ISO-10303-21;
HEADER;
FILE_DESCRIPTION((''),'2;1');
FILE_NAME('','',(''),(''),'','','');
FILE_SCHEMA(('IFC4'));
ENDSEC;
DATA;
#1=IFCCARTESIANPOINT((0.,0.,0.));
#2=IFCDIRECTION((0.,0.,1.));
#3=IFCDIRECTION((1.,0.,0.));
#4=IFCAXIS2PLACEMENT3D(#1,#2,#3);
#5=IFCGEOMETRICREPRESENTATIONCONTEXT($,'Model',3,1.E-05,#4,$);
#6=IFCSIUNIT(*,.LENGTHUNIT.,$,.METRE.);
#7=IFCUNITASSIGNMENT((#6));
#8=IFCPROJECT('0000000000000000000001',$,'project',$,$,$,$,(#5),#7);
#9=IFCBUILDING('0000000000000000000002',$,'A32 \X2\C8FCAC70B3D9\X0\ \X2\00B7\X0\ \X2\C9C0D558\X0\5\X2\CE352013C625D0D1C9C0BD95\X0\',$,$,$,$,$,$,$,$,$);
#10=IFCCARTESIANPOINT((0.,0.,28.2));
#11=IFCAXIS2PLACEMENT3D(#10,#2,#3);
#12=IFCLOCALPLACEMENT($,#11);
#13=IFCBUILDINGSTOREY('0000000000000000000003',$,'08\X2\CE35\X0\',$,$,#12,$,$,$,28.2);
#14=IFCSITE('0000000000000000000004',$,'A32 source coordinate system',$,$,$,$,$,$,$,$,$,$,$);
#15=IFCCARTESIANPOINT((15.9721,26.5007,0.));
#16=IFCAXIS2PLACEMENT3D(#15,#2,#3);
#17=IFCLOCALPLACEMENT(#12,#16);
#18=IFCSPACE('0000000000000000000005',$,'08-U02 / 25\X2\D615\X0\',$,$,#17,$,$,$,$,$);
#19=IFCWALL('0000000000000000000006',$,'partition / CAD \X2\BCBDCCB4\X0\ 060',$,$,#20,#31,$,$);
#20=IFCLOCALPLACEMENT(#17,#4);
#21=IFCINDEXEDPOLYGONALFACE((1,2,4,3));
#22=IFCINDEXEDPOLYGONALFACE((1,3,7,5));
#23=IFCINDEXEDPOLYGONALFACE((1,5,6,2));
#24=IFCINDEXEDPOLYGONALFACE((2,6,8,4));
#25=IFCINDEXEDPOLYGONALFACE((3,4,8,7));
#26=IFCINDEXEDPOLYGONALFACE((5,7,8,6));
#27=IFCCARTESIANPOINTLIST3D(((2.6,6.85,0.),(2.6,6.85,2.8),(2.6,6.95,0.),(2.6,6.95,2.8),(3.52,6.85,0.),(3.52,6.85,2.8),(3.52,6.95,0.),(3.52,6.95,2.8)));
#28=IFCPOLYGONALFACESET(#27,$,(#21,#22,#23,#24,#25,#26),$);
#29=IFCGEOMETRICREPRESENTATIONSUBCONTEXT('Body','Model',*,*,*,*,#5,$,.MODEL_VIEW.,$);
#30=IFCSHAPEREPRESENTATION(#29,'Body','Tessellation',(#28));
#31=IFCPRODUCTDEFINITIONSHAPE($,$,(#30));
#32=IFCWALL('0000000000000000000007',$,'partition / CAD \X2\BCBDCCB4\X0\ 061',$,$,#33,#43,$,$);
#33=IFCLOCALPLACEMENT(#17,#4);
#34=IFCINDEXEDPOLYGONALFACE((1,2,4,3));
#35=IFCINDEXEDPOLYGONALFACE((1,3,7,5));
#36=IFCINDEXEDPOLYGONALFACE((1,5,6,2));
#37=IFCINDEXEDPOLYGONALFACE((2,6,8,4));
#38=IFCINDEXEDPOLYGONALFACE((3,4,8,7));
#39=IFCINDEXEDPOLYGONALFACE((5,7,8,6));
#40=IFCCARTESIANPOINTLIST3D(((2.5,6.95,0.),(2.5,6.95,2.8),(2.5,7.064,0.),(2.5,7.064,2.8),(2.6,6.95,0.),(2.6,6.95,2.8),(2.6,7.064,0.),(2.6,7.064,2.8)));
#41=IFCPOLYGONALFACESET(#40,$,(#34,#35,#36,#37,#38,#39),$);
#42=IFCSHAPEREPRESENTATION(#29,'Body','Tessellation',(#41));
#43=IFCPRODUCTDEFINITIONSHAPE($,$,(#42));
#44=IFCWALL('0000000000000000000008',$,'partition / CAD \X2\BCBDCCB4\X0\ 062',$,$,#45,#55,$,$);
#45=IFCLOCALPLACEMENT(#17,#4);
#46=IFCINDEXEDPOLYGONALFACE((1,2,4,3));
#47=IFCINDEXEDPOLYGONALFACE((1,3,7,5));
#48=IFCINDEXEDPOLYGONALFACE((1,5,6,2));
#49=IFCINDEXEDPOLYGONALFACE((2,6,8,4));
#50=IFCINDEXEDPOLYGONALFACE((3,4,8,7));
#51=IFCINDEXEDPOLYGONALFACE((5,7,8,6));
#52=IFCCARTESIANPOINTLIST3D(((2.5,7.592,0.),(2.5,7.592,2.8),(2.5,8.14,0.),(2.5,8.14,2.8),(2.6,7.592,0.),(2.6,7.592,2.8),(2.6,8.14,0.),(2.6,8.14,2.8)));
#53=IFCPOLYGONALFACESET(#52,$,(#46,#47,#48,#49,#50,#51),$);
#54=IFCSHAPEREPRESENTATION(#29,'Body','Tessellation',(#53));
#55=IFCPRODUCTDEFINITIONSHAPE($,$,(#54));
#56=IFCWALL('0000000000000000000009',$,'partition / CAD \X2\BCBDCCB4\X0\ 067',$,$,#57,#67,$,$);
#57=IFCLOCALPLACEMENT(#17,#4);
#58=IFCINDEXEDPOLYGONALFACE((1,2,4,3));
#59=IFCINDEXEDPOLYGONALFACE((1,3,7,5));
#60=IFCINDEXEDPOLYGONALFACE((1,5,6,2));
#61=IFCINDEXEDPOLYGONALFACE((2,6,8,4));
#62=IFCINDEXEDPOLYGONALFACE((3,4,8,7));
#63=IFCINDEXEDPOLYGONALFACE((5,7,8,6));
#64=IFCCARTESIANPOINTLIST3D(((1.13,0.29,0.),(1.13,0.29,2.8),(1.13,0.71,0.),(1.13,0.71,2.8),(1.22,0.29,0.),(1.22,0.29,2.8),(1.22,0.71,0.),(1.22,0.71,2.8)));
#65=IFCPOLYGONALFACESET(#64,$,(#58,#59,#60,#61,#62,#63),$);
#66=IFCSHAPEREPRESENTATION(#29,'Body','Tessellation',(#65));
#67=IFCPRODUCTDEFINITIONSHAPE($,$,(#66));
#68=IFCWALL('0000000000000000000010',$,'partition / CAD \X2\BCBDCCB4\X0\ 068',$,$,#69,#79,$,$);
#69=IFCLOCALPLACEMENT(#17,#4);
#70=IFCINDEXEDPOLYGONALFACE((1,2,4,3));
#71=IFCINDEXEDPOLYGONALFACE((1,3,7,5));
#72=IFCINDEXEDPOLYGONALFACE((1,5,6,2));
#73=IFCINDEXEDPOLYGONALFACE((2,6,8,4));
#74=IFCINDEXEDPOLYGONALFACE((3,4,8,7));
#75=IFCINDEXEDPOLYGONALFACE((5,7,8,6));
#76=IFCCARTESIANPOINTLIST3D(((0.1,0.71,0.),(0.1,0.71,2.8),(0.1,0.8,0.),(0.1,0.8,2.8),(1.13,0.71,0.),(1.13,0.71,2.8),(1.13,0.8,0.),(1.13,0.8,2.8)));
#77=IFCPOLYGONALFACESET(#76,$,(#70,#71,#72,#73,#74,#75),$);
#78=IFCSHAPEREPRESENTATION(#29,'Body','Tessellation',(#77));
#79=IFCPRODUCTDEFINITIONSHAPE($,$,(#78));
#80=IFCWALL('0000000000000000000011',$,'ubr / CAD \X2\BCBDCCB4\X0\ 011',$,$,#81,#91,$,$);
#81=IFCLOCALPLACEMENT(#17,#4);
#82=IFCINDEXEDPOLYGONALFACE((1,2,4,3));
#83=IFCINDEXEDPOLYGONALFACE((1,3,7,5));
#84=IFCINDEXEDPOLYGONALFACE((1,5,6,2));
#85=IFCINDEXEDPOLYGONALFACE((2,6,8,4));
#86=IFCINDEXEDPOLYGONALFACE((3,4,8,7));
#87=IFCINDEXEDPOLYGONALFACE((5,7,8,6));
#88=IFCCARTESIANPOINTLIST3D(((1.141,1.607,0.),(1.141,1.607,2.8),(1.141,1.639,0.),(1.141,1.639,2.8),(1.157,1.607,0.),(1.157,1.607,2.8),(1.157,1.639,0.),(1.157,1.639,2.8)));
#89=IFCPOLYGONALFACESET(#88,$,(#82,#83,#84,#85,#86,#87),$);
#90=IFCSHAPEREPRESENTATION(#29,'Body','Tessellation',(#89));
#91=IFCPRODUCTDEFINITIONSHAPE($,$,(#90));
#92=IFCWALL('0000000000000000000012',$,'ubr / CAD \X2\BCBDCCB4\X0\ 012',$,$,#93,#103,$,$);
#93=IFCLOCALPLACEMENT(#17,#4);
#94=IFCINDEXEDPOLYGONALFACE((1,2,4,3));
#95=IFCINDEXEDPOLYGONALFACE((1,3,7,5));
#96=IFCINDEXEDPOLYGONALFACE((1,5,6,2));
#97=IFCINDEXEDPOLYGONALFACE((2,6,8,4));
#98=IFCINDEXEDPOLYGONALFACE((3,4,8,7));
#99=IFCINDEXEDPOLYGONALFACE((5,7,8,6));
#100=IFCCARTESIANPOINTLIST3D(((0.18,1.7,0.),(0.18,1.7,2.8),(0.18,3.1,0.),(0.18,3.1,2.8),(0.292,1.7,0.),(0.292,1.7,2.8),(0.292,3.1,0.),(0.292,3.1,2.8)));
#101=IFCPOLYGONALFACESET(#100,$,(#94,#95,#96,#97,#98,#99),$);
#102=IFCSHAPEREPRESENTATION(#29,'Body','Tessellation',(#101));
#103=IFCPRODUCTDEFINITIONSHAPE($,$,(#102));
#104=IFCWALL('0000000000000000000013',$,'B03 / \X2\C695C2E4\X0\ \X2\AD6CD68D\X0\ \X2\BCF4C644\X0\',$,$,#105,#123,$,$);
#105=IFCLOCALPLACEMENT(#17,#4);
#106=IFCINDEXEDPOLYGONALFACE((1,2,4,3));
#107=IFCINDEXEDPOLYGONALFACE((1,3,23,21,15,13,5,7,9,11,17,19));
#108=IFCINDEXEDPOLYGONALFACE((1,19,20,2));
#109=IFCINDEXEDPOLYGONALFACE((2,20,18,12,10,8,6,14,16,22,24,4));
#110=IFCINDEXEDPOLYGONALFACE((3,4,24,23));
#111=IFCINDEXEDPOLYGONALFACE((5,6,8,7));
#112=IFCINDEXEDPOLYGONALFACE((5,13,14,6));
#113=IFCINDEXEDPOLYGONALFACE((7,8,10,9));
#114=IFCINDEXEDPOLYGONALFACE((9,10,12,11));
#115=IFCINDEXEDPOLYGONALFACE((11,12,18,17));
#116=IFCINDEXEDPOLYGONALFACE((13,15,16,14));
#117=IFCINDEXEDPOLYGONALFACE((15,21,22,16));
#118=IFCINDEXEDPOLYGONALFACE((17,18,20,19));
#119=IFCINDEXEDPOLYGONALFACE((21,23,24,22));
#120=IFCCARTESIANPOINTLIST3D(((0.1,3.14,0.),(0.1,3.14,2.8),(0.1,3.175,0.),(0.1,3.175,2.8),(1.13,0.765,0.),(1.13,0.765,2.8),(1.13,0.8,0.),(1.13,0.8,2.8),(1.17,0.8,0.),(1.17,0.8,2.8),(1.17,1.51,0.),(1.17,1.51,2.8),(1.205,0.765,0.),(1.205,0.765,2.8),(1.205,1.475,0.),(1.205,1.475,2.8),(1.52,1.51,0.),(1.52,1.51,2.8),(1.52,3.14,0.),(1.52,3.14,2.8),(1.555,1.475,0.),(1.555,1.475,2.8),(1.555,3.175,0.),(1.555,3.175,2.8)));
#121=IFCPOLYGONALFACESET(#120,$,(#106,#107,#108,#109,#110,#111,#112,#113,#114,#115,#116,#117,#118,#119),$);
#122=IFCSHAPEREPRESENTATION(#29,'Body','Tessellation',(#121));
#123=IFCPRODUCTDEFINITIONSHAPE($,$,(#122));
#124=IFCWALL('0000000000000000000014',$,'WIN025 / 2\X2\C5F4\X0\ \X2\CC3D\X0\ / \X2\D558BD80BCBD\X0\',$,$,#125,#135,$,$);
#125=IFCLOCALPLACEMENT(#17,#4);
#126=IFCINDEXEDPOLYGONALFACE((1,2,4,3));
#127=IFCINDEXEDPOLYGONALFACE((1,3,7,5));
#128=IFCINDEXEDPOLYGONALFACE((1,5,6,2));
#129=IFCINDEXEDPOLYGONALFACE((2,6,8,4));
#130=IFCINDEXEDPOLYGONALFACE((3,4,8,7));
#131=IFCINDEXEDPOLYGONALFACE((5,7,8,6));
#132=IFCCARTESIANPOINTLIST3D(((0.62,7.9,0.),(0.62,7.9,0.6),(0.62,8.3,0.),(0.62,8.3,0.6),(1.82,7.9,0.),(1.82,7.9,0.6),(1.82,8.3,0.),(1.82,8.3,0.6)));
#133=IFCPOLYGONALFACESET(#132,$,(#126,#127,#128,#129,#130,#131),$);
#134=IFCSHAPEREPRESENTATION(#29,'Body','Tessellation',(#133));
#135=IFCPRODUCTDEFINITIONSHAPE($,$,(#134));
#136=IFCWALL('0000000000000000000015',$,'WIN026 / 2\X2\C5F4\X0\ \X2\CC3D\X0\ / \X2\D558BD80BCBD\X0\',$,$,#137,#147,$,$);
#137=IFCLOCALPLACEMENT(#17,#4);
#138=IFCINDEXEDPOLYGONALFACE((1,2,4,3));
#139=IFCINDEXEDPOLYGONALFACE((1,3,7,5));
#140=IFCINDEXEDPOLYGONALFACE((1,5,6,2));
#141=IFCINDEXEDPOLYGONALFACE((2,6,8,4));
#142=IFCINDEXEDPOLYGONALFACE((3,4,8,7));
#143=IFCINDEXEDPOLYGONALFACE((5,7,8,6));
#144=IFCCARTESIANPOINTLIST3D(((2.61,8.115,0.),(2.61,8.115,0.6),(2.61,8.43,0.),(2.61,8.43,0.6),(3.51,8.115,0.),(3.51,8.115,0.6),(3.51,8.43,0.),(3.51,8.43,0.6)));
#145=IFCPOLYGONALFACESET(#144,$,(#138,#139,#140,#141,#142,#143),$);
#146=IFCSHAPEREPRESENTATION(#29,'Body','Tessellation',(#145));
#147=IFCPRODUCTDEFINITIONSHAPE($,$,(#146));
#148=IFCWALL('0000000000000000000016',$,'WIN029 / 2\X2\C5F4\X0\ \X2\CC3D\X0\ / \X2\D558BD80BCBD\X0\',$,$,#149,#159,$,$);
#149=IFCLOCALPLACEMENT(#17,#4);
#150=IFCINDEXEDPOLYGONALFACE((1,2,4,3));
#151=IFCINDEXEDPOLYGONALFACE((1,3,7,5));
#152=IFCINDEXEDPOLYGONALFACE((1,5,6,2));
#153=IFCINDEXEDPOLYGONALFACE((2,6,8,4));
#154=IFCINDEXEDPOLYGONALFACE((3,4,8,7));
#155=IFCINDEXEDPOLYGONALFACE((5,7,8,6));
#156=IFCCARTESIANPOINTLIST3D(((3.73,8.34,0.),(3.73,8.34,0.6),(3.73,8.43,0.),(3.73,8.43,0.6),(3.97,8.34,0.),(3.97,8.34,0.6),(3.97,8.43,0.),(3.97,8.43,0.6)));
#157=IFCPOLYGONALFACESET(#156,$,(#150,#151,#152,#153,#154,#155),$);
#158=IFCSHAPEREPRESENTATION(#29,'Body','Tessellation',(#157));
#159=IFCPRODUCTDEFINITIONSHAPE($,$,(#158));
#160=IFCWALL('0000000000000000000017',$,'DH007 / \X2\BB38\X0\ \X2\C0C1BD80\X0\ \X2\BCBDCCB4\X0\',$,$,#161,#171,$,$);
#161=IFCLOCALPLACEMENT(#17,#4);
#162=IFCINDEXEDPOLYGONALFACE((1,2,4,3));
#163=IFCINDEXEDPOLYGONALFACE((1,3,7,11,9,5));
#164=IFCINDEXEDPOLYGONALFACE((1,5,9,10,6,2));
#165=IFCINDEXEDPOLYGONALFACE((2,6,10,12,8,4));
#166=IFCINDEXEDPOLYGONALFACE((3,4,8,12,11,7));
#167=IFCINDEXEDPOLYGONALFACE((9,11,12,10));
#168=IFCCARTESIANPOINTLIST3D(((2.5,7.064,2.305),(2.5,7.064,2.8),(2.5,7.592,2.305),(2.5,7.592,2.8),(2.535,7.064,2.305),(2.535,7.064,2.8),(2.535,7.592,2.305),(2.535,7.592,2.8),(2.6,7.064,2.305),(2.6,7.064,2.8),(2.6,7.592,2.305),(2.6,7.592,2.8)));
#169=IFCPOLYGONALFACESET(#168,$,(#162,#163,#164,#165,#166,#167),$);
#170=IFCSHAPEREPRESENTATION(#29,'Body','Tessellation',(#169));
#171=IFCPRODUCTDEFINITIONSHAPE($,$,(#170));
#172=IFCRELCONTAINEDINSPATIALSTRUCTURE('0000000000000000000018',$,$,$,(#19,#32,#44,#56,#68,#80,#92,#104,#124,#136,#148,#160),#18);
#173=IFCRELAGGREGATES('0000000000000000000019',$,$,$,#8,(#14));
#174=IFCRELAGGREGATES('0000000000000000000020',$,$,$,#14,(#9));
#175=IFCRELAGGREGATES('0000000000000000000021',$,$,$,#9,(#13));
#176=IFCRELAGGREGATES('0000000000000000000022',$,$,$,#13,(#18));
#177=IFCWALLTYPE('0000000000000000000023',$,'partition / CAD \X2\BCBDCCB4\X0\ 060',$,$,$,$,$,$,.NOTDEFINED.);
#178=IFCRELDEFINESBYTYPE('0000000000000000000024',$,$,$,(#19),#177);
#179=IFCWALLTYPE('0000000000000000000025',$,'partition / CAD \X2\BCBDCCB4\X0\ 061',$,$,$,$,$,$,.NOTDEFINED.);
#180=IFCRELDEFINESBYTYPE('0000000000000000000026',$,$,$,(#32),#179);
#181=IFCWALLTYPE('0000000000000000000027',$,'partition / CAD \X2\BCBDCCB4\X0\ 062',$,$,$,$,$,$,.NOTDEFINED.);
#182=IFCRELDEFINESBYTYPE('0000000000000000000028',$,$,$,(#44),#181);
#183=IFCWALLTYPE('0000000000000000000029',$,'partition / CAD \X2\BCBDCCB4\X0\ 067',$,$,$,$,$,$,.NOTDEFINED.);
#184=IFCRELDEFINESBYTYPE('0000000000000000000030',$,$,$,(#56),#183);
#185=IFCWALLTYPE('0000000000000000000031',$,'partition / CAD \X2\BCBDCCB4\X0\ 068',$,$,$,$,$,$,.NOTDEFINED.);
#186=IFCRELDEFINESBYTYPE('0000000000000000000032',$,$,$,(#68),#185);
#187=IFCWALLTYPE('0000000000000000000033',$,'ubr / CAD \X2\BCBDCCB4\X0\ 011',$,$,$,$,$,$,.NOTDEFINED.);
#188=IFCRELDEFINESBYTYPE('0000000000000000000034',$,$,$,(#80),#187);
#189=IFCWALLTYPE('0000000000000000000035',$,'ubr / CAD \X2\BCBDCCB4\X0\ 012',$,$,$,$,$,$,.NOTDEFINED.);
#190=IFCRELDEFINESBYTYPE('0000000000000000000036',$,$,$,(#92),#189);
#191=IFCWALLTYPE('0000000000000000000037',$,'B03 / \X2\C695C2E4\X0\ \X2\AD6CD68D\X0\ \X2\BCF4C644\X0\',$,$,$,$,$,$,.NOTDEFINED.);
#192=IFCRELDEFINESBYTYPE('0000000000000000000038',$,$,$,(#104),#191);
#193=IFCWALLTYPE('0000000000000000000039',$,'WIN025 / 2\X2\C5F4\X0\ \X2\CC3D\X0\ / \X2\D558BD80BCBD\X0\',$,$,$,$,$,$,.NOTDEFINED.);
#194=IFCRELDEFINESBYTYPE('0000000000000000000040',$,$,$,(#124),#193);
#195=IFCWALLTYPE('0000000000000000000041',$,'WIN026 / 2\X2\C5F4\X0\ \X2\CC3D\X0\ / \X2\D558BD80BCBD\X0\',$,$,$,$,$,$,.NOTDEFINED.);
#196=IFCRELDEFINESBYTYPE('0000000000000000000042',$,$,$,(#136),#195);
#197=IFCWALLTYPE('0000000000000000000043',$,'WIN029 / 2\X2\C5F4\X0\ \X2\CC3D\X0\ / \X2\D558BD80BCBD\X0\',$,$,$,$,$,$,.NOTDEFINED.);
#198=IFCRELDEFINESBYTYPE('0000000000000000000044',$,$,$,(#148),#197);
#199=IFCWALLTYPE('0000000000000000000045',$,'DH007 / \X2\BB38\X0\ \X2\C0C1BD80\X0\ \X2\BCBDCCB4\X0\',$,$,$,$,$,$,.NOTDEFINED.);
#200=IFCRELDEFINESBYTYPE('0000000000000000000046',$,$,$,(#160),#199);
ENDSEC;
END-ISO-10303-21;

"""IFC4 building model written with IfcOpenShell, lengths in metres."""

from ifc_helpers import new_model, si_unit, frame, origin, origin_with_axes, place, context, subcontext, project, spatial, polyline, outline, extrude, source, transform, mapped, type_object, type_shapes, element, save


model = new_model("IFC4")

# Units and contexts
model_context = context("Model", 3, precision=1e-05, world=origin_with_axes())
body_context = subcontext(model_context, "Body", "Model", "MODEL_VIEW")
ifc_project = project(units=[si_unit("LENGTHUNIT", "METRE")], contexts=[model_context])

# Site, building, storey, space
site = spatial("IfcSite", under=ifc_project, Name="A32 source coordinate system")
building = spatial("IfcBuilding", under=site, Name="A32 주거동 · 지하5층–옥탑지붕")
storey_placement = place(None, frame((0.0, 0.0, 28.2), z_axis=(0.0, 0.0, 1.0), x_axis=(1.0, 0.0, 0.0)))
storey = spatial("IfcBuildingStorey", under=building, at=storey_placement, Name="08층", Elevation=28.2)
space_1_placement = place(storey_placement, frame((15.9721, 26.5007, 0.0), z_axis=(0.0, 0.0, 1.0), x_axis=(1.0, 0.0, 0.0)))
space_1 = spatial("IfcSpace", under=storey, at=space_1_placement, Name="08-U02 / 25형")

# Walls
wall_type_1 = type_object("IfcWallType", Name="partition / CAD 벽체 060", PredefinedType="NOTDEFINED")
shared_shape_1 = source(origin(), body_context, "Body", "SweptSolid", [
    extrude(outline(polyline([(3.52, 6.85), (2.6, 6.85), (2.6, 6.95), (3.52, 6.95), (3.52, 6.85)])), origin(), (0.0, 0.0, 1.0), 2.8),
])
type_shapes(wall_type_1, [shared_shape_1])
wall_1_placement = place(space_1_placement, origin_with_axes())
element("IfcWall", 1, at=wall_1_placement, inside=space_1, type_object=wall_type_1, Name="partition / CAD 벽체 060", context=body_context, shape_type="MappedRepresentation", body=[
    mapped(shared_shape_1, transform((0.0, 0.0, 0.0), scale=1.0)),
])
wall_type_2 = type_object("IfcWallType", Name="partition / CAD 벽체 061", PredefinedType="NOTDEFINED")
shared_shape_2 = source(origin(), body_context, "Body", "SweptSolid", [
    extrude(outline(polyline([(2.6, 7.064), (2.6, 6.95), (2.5, 6.95), (2.5, 7.064), (2.6, 7.064)])), origin(), (0.0, 0.0, 1.0), 2.8),
])
type_shapes(wall_type_2, [shared_shape_2])
wall_2_placement = place(space_1_placement, origin_with_axes())
element("IfcWall", 2, at=wall_2_placement, inside=space_1, type_object=wall_type_2, Name="partition / CAD 벽체 061", context=body_context, shape_type="MappedRepresentation", body=[
    mapped(shared_shape_2, transform((0.0, 0.0, 0.0), scale=1.0)),
])
wall_type_3 = type_object("IfcWallType", Name="partition / CAD 벽체 062", PredefinedType="NOTDEFINED")
shared_shape_3 = source(origin(), body_context, "Body", "SweptSolid", [
    extrude(outline(polyline([(2.5, 7.592), (2.5, 8.14), (2.6, 8.14), (2.6, 7.592), (2.5, 7.592)])), origin(), (0.0, 0.0, 1.0), 2.8),
])
type_shapes(wall_type_3, [shared_shape_3])
wall_3_placement = place(space_1_placement, origin_with_axes())
element("IfcWall", 3, at=wall_3_placement, inside=space_1, type_object=wall_type_3, Name="partition / CAD 벽체 062", context=body_context, shape_type="MappedRepresentation", body=[
    mapped(shared_shape_3, transform((0.0, 0.0, 0.0), scale=1.0)),
])
wall_type_4 = type_object("IfcWallType", Name="partition / CAD 벽체 067", PredefinedType="NOTDEFINED")
shared_shape_4 = source(origin(), body_context, "Body", "SweptSolid", [
    extrude(outline(polyline([(1.22, 0.71), (1.22, 0.29), (1.13, 0.29), (1.13, 0.71), (1.22, 0.71)])), origin(), (0.0, 0.0, 1.0), 2.8),
])
type_shapes(wall_type_4, [shared_shape_4])
wall_4_placement = place(space_1_placement, origin_with_axes())
element("IfcWall", 4, at=wall_4_placement, inside=space_1, type_object=wall_type_4, Name="partition / CAD 벽체 067", context=body_context, shape_type="MappedRepresentation", body=[
    mapped(shared_shape_4, transform((0.0, 0.0, 0.0), scale=1.0)),
])
wall_type_5 = type_object("IfcWallType", Name="partition / CAD 벽체 068", PredefinedType="NOTDEFINED")
shared_shape_5 = source(origin(), body_context, "Body", "SweptSolid", [
    extrude(outline(polyline([(1.13, 0.8), (1.13, 0.71), (0.1, 0.71), (0.1, 0.8), (1.13, 0.8)])), origin(), (0.0, 0.0, 1.0), 2.8),
])
type_shapes(wall_type_5, [shared_shape_5])
wall_5_placement = place(space_1_placement, origin_with_axes())
element("IfcWall", 5, at=wall_5_placement, inside=space_1, type_object=wall_type_5, Name="partition / CAD 벽체 068", context=body_context, shape_type="MappedRepresentation", body=[
    mapped(shared_shape_5, transform((0.0, 0.0, 0.0), scale=1.0)),
])
wall_type_6 = type_object("IfcWallType", Name="ubr / CAD 벽체 011", PredefinedType="NOTDEFINED")
shared_shape_6 = source(origin(), body_context, "Body", "SweptSolid", [
    extrude(outline(polyline([(1.141, 1.607), (1.141, 1.639), (1.157, 1.639), (1.157, 1.607), (1.141, 1.607)])), origin(), (0.0, 0.0, 1.0), 2.8),
])
type_shapes(wall_type_6, [shared_shape_6])
wall_6_placement = place(space_1_placement, origin_with_axes())
element("IfcWall", 6, at=wall_6_placement, inside=space_1, type_object=wall_type_6, Name="ubr / CAD 벽체 011", context=body_context, shape_type="MappedRepresentation", body=[
    mapped(shared_shape_6, transform((0.0, 0.0, 0.0), scale=1.0)),
])
wall_type_7 = type_object("IfcWallType", Name="ubr / CAD 벽체 012", PredefinedType="NOTDEFINED")
shared_shape_7 = source(origin(), body_context, "Body", "SweptSolid", [
    extrude(outline(polyline([(0.18, 1.7), (0.18, 3.1), (0.292, 3.1), (0.292, 1.7), (0.18, 1.7)])), origin(), (0.0, 0.0, 1.0), 2.8),
])
type_shapes(wall_type_7, [shared_shape_7])
wall_7_placement = place(space_1_placement, origin_with_axes())
element("IfcWall", 7, at=wall_7_placement, inside=space_1, type_object=wall_type_7, Name="ubr / CAD 벽체 012", context=body_context, shape_type="MappedRepresentation", body=[
    mapped(shared_shape_7, transform((0.0, 0.0, 0.0), scale=1.0)),
])
wall_type_8 = type_object("IfcWallType", Name="B03 / 욕실 구획 보완", PredefinedType="NOTDEFINED")
shared_shape_8 = source(origin(), body_context, "Body", "SweptSolid", [
    extrude(outline(polyline([(1.13, 0.765), (1.13, 0.8), (1.17, 0.8), (1.17, 1.51), (1.52, 1.51), (1.52, 3.14), (0.1, 3.14), (0.1, 3.175), (1.555, 3.175), (1.555, 1.475), (1.205, 1.475), (1.205, 0.765), (1.13, 0.765)])), origin(), (0.0, 0.0, 1.0), 2.8),
])
type_shapes(wall_type_8, [shared_shape_8])
wall_8_placement = place(space_1_placement, origin_with_axes())
element("IfcWall", 8, at=wall_8_placement, inside=space_1, type_object=wall_type_8, Name="B03 / 욕실 구획 보완", context=body_context, shape_type="MappedRepresentation", body=[
    mapped(shared_shape_8, transform((0.0, 0.0, 0.0), scale=1.0)),
])
wall_type_9 = type_object("IfcWallType", Name="WIN025 / 2열 창 / 하부벽", PredefinedType="NOTDEFINED")
shared_shape_9 = source(origin(), body_context, "Body", "SweptSolid", [
    extrude(outline(polyline([(1.82, 8.3), (1.82, 7.9), (0.62, 7.9), (0.62, 8.3), (1.82, 8.3)])), origin(), (0.0, 0.0, 1.0), 0.6),
])
type_shapes(wall_type_9, [shared_shape_9])
wall_9_placement = place(space_1_placement, origin_with_axes())
element("IfcWall", 9, at=wall_9_placement, inside=space_1, type_object=wall_type_9, Name="WIN025 / 2열 창 / 하부벽", context=body_context, shape_type="MappedRepresentation", body=[
    mapped(shared_shape_9, transform((0.0, 0.0, 0.0), scale=1.0)),
])
wall_type_10 = type_object("IfcWallType", Name="WIN026 / 2열 창 / 하부벽", PredefinedType="NOTDEFINED")
shared_shape_10 = source(origin(), body_context, "Body", "SweptSolid", [
    extrude(outline(polyline([(3.51, 8.43), (3.51, 8.115), (2.61, 8.115), (2.61, 8.43), (3.51, 8.43)])), origin(), (0.0, 0.0, 1.0), 0.6),
])
type_shapes(wall_type_10, [shared_shape_10])
wall_10_placement = place(space_1_placement, origin_with_axes())
element("IfcWall", 10, at=wall_10_placement, inside=space_1, type_object=wall_type_10, Name="WIN026 / 2열 창 / 하부벽", context=body_context, shape_type="MappedRepresentation", body=[
    mapped(shared_shape_10, transform((0.0, 0.0, 0.0), scale=1.0)),
])
wall_type_11 = type_object("IfcWallType", Name="WIN029 / 2열 창 / 하부벽", PredefinedType="NOTDEFINED")
shared_shape_11 = source(origin(), body_context, "Body", "SweptSolid", [
    extrude(outline(polyline([(3.97, 8.43), (3.97, 8.34), (3.73, 8.34), (3.73, 8.43), (3.97, 8.43)])), origin(), (0.0, 0.0, 1.0), 0.6),
])
type_shapes(wall_type_11, [shared_shape_11])
wall_11_placement = place(space_1_placement, origin_with_axes())
element("IfcWall", 11, at=wall_11_placement, inside=space_1, type_object=wall_type_11, Name="WIN029 / 2열 창 / 하부벽", context=body_context, shape_type="MappedRepresentation", body=[
    mapped(shared_shape_11, transform((0.0, 0.0, 0.0), scale=1.0)),
])
wall_type_12 = type_object("IfcWallType", Name="DH007 / 문 상부 벽체", PredefinedType="NOTDEFINED")
shared_shape_12 = source(origin(), body_context, "Body", "SweptSolid", [
    extrude(outline(polyline([(2.5, 7.592), (2.535, 7.592), (2.6, 7.592), (2.6, 7.064), (2.535, 7.064), (2.5, 7.064), (2.5, 7.592)])), frame((0.0, 0.0, 2.305)), (0.0, 0.0, 1.0), 0.495),
])
type_shapes(wall_type_12, [shared_shape_12])
wall_12_placement = place(space_1_placement, origin_with_axes())
element("IfcWall", 12, at=wall_12_placement, inside=space_1, type_object=wall_type_12, Name="DH007 / 문 상부 벽체", context=body_context, shape_type="MappedRepresentation", body=[
    mapped(shared_shape_12, transform((0.0, 0.0, 0.0), scale=1.0)),
])

save(model, "model.ifc")
